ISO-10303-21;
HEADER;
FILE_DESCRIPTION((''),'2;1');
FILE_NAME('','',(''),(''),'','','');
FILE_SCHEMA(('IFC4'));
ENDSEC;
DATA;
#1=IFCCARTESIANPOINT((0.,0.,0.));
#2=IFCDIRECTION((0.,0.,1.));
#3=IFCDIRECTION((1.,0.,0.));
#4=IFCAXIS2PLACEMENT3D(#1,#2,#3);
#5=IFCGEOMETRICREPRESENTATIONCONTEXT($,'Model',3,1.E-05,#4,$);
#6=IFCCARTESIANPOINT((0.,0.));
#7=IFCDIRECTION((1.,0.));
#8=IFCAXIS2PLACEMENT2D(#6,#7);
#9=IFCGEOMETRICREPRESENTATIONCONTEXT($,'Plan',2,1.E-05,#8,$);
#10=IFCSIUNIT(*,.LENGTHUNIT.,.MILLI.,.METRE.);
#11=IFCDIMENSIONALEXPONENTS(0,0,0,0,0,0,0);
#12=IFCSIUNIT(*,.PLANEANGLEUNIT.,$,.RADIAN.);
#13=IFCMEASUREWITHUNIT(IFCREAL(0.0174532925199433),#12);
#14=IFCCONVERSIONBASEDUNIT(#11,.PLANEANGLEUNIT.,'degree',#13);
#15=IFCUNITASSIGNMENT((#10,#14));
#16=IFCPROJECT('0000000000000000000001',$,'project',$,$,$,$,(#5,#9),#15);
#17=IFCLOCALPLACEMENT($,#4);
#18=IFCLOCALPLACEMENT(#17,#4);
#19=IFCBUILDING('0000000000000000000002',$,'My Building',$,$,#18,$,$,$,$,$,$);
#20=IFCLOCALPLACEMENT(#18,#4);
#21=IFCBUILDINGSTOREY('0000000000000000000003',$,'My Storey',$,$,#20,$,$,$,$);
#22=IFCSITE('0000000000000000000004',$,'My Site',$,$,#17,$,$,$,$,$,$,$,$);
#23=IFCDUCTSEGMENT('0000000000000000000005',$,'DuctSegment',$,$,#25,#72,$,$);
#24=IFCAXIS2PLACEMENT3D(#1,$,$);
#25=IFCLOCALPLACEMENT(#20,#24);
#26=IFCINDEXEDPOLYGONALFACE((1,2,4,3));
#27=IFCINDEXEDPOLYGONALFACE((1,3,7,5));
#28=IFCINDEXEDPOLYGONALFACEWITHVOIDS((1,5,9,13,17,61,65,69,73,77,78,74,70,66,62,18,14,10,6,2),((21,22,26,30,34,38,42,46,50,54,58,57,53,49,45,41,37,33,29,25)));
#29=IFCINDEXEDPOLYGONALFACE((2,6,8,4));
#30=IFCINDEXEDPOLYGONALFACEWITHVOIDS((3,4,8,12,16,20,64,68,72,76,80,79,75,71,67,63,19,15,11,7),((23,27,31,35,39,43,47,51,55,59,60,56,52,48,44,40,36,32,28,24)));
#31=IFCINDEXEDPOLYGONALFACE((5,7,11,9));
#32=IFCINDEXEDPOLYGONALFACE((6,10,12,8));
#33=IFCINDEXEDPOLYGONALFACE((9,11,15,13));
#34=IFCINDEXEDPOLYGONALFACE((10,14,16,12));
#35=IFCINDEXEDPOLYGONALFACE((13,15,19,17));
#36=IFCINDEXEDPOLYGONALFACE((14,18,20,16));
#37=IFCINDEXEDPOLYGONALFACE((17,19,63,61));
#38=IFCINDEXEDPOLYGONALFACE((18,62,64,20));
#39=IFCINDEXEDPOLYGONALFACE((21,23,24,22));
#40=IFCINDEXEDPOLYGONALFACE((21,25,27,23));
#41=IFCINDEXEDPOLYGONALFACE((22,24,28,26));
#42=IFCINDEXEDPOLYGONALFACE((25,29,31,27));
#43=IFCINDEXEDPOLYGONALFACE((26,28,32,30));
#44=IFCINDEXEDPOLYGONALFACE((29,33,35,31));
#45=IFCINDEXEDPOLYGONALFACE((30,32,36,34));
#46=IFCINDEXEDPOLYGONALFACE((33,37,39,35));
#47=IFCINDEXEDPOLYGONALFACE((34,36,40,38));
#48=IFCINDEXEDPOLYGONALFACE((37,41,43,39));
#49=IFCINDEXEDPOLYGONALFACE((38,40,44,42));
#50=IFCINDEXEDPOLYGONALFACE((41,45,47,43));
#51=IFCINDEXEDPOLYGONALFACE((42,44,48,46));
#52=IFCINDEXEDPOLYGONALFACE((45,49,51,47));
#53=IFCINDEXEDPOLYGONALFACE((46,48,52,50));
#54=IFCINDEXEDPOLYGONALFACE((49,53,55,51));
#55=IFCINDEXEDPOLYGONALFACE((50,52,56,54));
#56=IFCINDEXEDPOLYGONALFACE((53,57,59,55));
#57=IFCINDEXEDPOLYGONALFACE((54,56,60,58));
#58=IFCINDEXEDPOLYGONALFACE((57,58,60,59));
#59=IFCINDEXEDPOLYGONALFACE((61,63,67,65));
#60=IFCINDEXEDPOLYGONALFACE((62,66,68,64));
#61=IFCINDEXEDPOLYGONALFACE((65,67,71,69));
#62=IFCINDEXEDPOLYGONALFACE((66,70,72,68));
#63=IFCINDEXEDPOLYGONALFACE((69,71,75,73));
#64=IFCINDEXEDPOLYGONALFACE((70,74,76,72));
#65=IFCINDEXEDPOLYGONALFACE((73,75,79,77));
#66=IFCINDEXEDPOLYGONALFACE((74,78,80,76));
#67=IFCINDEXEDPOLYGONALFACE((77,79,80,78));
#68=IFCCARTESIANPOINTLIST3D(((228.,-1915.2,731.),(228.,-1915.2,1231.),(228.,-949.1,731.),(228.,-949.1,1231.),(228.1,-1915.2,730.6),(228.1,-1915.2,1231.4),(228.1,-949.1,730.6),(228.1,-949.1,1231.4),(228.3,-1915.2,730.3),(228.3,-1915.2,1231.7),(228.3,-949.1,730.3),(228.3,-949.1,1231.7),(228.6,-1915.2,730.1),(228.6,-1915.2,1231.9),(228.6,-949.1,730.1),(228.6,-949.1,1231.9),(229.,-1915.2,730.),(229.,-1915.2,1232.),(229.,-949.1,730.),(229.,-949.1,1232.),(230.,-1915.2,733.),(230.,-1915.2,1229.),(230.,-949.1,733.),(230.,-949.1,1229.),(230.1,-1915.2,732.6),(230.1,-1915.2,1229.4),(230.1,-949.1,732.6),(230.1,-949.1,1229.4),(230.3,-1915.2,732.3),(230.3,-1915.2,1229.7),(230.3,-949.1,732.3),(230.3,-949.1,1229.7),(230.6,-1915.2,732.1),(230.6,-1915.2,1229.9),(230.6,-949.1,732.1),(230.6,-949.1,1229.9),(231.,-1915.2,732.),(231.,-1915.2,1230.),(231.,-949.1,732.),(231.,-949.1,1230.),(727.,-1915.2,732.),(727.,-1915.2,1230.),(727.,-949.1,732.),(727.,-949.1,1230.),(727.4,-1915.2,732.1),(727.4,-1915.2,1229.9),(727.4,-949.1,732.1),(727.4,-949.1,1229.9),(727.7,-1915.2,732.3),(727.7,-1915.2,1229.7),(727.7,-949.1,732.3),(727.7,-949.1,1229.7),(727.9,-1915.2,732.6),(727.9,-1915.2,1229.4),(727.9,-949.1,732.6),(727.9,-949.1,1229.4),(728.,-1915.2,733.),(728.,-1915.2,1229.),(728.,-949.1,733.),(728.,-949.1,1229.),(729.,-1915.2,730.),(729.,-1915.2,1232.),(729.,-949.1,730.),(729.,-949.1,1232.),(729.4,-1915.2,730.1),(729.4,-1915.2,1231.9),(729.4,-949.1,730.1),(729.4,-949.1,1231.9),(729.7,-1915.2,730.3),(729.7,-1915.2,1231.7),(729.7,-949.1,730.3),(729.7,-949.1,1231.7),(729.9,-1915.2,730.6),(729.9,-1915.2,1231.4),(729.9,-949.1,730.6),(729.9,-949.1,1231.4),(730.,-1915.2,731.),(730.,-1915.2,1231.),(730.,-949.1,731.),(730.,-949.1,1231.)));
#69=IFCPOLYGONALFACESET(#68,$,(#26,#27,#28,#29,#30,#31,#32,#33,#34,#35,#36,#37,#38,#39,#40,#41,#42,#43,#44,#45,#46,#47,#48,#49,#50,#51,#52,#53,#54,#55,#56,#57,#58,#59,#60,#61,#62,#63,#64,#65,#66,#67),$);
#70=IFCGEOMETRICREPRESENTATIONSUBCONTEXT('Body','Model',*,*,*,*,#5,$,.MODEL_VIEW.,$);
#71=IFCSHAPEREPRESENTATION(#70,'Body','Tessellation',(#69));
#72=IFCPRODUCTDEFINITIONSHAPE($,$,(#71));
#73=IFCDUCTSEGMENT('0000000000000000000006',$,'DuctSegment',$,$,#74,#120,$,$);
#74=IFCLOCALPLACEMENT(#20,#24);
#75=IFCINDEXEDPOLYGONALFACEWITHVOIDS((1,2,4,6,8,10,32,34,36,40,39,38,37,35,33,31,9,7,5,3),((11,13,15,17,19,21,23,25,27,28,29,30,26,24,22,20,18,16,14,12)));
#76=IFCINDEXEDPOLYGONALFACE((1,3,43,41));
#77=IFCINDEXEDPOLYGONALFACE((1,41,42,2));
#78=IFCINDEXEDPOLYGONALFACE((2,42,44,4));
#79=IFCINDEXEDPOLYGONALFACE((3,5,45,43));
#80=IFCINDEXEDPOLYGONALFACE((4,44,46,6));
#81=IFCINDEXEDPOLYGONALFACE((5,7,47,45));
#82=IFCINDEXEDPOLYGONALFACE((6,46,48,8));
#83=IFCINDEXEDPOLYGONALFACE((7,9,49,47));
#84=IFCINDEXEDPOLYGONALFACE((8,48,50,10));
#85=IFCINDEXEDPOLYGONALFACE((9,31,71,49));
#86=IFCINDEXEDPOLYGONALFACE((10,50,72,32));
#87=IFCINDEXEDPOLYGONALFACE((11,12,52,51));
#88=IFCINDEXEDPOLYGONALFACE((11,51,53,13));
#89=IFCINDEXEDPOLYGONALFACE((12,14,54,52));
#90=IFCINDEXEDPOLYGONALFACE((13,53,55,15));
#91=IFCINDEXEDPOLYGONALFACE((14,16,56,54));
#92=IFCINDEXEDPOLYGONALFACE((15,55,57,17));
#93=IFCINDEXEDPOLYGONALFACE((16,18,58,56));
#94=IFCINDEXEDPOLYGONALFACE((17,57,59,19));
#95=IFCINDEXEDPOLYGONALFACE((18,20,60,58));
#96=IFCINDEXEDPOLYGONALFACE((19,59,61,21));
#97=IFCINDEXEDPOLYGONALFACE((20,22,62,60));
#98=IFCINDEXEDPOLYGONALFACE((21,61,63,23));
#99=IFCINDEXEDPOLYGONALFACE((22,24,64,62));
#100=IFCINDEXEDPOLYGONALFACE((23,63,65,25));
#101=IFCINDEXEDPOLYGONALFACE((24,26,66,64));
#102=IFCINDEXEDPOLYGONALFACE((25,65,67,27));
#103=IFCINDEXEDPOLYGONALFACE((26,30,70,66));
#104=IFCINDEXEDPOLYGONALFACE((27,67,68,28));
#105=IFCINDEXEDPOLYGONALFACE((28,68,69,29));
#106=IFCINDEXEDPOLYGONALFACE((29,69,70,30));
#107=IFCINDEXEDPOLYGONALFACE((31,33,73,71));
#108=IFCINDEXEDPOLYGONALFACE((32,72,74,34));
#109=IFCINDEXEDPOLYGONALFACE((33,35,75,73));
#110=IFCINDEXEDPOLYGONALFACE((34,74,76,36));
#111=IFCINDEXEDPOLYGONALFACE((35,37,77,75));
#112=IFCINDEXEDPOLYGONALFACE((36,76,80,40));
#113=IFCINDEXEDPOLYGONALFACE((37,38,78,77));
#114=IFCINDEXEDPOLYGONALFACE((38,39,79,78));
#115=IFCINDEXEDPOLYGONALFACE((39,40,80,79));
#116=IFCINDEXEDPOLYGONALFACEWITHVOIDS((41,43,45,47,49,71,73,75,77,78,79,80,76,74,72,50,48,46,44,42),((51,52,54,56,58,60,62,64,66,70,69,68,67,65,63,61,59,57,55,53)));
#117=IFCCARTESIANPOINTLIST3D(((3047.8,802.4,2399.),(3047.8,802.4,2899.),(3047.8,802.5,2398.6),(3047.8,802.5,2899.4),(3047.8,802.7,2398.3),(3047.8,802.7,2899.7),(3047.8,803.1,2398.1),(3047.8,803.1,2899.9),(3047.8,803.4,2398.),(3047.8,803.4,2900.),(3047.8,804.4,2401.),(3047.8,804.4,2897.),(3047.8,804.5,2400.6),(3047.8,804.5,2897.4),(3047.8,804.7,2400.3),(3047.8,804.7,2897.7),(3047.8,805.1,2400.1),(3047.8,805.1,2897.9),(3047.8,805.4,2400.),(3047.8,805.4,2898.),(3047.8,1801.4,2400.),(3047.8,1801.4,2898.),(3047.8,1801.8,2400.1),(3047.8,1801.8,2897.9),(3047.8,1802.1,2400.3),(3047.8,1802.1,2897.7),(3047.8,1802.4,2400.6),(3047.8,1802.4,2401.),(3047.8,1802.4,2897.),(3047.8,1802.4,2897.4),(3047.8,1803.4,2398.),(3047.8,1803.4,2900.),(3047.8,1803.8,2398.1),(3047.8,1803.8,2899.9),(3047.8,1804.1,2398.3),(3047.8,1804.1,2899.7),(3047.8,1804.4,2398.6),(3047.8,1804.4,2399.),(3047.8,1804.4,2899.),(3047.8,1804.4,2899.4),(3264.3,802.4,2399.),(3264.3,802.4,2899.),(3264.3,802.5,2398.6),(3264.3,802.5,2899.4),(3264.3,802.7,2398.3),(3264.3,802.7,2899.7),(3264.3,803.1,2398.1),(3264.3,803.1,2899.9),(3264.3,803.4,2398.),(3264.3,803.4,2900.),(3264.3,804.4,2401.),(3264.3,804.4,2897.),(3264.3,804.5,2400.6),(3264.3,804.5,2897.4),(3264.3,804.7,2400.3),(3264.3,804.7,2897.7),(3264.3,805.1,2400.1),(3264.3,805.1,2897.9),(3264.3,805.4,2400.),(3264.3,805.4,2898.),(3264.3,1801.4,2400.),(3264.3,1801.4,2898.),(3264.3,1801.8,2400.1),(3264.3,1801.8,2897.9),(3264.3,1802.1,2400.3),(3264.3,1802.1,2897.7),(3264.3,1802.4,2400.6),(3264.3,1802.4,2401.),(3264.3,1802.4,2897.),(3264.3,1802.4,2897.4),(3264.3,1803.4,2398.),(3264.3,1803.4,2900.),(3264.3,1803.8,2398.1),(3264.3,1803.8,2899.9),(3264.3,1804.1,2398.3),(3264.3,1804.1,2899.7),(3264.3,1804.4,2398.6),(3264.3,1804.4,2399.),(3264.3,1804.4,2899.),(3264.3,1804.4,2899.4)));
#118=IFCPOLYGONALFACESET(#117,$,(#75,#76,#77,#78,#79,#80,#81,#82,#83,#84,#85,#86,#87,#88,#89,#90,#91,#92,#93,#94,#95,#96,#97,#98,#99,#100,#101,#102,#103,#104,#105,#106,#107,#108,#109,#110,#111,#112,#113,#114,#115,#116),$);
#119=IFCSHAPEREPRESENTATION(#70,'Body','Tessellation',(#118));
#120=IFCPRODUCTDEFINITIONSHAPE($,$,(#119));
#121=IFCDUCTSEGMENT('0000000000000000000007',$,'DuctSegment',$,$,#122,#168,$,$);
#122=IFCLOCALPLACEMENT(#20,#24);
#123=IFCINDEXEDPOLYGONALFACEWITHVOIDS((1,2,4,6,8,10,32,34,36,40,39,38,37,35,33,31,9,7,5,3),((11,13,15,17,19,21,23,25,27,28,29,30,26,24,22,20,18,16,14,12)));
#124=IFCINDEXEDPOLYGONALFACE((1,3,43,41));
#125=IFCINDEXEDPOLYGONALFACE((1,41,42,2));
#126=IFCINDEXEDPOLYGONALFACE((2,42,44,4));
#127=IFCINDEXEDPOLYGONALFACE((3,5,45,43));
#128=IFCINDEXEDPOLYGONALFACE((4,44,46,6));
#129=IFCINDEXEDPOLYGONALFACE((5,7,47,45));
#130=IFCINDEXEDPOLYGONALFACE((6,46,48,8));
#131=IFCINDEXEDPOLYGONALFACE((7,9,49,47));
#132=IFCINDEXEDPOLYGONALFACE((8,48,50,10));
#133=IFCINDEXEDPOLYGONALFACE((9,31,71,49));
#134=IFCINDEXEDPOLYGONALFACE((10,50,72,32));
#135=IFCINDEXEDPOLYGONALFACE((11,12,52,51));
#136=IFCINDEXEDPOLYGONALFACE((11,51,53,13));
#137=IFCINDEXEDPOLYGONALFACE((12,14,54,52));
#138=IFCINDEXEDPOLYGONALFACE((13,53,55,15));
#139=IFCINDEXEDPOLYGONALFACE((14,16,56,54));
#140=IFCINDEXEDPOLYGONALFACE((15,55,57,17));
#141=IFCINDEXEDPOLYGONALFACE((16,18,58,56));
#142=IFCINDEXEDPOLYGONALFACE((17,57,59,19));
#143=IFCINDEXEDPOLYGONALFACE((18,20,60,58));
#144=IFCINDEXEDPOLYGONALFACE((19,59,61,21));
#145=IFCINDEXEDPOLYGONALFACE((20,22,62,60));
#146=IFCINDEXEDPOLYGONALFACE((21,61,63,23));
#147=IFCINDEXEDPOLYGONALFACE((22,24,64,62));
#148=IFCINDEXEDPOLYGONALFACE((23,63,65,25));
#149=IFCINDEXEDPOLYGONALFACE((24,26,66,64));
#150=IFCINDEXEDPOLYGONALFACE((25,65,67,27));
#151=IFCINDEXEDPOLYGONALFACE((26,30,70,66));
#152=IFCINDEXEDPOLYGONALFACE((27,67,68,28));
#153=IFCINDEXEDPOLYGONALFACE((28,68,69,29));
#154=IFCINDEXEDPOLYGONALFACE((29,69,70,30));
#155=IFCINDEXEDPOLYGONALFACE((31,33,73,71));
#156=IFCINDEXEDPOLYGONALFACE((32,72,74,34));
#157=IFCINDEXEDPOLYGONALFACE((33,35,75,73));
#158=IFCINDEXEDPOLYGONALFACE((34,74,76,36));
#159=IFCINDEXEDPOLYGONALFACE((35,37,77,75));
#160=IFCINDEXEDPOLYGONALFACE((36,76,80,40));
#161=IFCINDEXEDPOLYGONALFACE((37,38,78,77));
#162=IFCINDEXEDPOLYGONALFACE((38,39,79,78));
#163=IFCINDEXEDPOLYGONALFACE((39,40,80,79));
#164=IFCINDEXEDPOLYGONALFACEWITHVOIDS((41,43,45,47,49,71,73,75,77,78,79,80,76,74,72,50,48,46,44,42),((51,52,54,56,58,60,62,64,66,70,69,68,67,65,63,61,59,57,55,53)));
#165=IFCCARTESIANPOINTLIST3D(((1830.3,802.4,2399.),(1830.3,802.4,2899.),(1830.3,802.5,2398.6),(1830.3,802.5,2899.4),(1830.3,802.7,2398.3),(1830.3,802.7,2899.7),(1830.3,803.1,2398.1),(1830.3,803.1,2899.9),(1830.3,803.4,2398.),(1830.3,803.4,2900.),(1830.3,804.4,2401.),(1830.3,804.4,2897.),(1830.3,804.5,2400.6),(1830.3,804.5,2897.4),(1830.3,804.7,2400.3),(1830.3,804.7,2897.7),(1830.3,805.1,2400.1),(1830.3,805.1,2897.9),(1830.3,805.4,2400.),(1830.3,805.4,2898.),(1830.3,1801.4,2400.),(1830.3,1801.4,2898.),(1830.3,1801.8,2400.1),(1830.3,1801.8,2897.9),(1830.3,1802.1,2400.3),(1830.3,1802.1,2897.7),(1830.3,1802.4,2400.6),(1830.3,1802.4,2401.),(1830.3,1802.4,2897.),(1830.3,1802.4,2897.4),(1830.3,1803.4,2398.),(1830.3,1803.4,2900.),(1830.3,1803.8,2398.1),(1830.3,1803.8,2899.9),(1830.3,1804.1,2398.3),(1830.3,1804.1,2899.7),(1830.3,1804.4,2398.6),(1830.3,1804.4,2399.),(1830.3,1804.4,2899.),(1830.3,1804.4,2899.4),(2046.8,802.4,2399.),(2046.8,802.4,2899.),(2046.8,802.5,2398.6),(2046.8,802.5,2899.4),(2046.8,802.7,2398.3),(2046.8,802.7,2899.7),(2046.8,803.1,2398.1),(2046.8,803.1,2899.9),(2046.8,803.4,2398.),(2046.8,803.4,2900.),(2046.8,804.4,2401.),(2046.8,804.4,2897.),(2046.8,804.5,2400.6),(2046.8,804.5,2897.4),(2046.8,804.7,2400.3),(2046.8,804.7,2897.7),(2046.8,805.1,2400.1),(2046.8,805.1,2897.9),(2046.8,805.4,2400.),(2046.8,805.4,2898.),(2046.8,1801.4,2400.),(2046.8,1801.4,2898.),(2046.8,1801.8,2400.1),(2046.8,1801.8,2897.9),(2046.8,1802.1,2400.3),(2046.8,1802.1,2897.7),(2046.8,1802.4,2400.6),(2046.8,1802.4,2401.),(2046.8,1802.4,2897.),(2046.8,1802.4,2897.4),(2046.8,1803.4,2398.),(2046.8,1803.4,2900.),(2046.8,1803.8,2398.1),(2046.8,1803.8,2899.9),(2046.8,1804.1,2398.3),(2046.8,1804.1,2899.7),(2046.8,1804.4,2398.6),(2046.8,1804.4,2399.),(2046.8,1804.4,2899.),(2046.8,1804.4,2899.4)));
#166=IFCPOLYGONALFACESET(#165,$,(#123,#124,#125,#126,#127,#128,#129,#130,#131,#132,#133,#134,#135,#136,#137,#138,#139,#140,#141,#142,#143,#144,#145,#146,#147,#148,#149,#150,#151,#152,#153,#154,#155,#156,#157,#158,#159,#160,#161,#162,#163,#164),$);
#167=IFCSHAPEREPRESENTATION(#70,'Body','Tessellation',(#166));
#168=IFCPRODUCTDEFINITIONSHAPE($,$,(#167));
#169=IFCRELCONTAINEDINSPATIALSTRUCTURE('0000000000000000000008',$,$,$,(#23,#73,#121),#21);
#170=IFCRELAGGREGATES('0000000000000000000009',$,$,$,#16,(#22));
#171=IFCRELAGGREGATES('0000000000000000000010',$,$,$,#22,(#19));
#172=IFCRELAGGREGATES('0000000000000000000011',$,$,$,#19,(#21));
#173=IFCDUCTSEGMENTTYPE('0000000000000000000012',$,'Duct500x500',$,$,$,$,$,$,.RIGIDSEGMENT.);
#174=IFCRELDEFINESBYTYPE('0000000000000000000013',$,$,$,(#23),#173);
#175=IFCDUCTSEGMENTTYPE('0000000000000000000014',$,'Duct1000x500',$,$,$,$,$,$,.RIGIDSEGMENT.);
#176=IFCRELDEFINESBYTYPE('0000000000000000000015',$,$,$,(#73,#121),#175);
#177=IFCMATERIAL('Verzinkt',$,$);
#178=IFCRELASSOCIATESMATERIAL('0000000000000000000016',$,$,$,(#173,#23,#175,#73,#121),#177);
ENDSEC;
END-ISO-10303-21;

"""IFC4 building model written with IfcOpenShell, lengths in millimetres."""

from ifc_helpers import new_model, entity, si_unit, converted_unit, frame, origin_with_axes, origin_2d_with_axis, place, context, subcontext, project, spatial, hollow_rectangle, extrude, material, material_profile, profile_set, profile_usage, type_object, element, save


model = new_model("IFC4")

# Units and contexts
model_context = context("Model", 3, precision=1e-05, world=origin_with_axes())
plan_context = context("Plan", 2, precision=1e-05, world=origin_2d_with_axis())
body_context = subcontext(model_context, "Body", "Model", "MODEL_VIEW")
ifc_project = project(units=[si_unit("LENGTHUNIT", "METRE", prefix="MILLI"), converted_unit("PLANEANGLEUNIT", "degree", entity("IfcReal", 0.0174532925199433), si_unit("PLANEANGLEUNIT", "RADIAN"), dimensions=[0, 0, 0, 0, 0, 0, 0])], contexts=[model_context, plan_context])

# Site, building, storey
site_placement = place(None, origin_with_axes())
site = spatial("IfcSite", under=ifc_project, at=site_placement, Name="My Site")
building_placement = place(site_placement, origin_with_axes())
building = spatial("IfcBuilding", under=site, at=building_placement, Name="My Building")
storey_placement = place(building_placement, origin_with_axes())
storey = spatial("IfcBuildingStorey", under=building, at=storey_placement, Name="My Storey")

# Shared definitions
ifc_material = material(Name="Verzinkt")

# Duct segments
ifc_material_profile_1 = material_profile(ifc_material, hollow_rectangle(XDim=502.0, YDim=502.0, WallThickness=2.0, InnerFilletRadius=1.0, OuterFilletRadius=1.0))
ifc_profile_set_1 = profile_set([ifc_material_profile_1])
duct_segment_type_1 = type_object("IfcDuctSegmentType", Name="Duct500x500", PredefinedType="RIGIDSEGMENT", material=ifc_profile_set_1)
ifc_profile_usage_1 = profile_usage(ifc_profile_set_1, cardinal=5)
duct_segment_1_placement = place(storey_placement, frame((479.0, -949.1, 981.0), z_axis=(0.0, -1.0, 0.0), x_axis=(1.0, 0.0, 0.0)))
element("IfcDuctSegment", 1, at=duct_segment_1_placement, inside=storey, type_object=duct_segment_type_1, material=ifc_profile_usage_1, Name="DuctSegment", context=body_context, shape_type="SweptSolid", body=[
    extrude(hollow_rectangle(XDim=502.0, YDim=502.0, WallThickness=2.0, InnerFilletRadius=1.0, OuterFilletRadius=1.0), origin_with_axes(), (0.0, 0.0, 1.0), 966.0),
])
ifc_material_profile_2 = material_profile(ifc_material, hollow_rectangle(XDim=1002.0, YDim=502.0, WallThickness=2.0, InnerFilletRadius=1.0, OuterFilletRadius=1.0))
ifc_profile_set_2 = profile_set([ifc_material_profile_2])
ifc_profile_usage_2 = profile_usage(ifc_profile_set_2, cardinal=5)
duct_segment_type_2 = type_object("IfcDuctSegmentType", Name="Duct1000x500", PredefinedType="RIGIDSEGMENT", material=ifc_profile_set_2)
duct_segment_2_placement = place(storey_placement, frame((3264.3, 1303.4, 2649.0), z_axis=(-1.0, 0.0, 0.0), x_axis=(0.0, -1.0, 0.0)))
element("IfcDuctSegment", 2, at=duct_segment_2_placement, inside=storey, type_object=duct_segment_type_2, material=ifc_profile_usage_2, Name="DuctSegment", context=body_context, shape_type="SweptSolid", body=[
    extrude(hollow_rectangle(XDim=1002.0, YDim=502.0, WallThickness=2.0, InnerFilletRadius=1.0, OuterFilletRadius=1.0), origin_with_axes(), (0.0, 0.0, 1.0), 216.5),
])
ifc_profile_usage_3 = profile_usage(ifc_profile_set_2, cardinal=5)
duct_segment_3_placement = place(storey_placement, frame((2046.8, 1303.4, 2649.0), z_axis=(-1.0, 0.0, 0.0), x_axis=(0.0, -1.0, 0.0)))
element("IfcDuctSegment", 3, at=duct_segment_3_placement, inside=storey, type_object=duct_segment_type_2, material=ifc_profile_usage_3, Name="DuctSegment", context=body_context, shape_type="SweptSolid", body=[
    extrude(hollow_rectangle(XDim=1002.0, YDim=502.0, WallThickness=2.0, InnerFilletRadius=1.0, OuterFilletRadius=1.0), origin_with_axes(), (0.0, 0.0, 1.0), 216.5),
])

save(model, "model.ifc")
